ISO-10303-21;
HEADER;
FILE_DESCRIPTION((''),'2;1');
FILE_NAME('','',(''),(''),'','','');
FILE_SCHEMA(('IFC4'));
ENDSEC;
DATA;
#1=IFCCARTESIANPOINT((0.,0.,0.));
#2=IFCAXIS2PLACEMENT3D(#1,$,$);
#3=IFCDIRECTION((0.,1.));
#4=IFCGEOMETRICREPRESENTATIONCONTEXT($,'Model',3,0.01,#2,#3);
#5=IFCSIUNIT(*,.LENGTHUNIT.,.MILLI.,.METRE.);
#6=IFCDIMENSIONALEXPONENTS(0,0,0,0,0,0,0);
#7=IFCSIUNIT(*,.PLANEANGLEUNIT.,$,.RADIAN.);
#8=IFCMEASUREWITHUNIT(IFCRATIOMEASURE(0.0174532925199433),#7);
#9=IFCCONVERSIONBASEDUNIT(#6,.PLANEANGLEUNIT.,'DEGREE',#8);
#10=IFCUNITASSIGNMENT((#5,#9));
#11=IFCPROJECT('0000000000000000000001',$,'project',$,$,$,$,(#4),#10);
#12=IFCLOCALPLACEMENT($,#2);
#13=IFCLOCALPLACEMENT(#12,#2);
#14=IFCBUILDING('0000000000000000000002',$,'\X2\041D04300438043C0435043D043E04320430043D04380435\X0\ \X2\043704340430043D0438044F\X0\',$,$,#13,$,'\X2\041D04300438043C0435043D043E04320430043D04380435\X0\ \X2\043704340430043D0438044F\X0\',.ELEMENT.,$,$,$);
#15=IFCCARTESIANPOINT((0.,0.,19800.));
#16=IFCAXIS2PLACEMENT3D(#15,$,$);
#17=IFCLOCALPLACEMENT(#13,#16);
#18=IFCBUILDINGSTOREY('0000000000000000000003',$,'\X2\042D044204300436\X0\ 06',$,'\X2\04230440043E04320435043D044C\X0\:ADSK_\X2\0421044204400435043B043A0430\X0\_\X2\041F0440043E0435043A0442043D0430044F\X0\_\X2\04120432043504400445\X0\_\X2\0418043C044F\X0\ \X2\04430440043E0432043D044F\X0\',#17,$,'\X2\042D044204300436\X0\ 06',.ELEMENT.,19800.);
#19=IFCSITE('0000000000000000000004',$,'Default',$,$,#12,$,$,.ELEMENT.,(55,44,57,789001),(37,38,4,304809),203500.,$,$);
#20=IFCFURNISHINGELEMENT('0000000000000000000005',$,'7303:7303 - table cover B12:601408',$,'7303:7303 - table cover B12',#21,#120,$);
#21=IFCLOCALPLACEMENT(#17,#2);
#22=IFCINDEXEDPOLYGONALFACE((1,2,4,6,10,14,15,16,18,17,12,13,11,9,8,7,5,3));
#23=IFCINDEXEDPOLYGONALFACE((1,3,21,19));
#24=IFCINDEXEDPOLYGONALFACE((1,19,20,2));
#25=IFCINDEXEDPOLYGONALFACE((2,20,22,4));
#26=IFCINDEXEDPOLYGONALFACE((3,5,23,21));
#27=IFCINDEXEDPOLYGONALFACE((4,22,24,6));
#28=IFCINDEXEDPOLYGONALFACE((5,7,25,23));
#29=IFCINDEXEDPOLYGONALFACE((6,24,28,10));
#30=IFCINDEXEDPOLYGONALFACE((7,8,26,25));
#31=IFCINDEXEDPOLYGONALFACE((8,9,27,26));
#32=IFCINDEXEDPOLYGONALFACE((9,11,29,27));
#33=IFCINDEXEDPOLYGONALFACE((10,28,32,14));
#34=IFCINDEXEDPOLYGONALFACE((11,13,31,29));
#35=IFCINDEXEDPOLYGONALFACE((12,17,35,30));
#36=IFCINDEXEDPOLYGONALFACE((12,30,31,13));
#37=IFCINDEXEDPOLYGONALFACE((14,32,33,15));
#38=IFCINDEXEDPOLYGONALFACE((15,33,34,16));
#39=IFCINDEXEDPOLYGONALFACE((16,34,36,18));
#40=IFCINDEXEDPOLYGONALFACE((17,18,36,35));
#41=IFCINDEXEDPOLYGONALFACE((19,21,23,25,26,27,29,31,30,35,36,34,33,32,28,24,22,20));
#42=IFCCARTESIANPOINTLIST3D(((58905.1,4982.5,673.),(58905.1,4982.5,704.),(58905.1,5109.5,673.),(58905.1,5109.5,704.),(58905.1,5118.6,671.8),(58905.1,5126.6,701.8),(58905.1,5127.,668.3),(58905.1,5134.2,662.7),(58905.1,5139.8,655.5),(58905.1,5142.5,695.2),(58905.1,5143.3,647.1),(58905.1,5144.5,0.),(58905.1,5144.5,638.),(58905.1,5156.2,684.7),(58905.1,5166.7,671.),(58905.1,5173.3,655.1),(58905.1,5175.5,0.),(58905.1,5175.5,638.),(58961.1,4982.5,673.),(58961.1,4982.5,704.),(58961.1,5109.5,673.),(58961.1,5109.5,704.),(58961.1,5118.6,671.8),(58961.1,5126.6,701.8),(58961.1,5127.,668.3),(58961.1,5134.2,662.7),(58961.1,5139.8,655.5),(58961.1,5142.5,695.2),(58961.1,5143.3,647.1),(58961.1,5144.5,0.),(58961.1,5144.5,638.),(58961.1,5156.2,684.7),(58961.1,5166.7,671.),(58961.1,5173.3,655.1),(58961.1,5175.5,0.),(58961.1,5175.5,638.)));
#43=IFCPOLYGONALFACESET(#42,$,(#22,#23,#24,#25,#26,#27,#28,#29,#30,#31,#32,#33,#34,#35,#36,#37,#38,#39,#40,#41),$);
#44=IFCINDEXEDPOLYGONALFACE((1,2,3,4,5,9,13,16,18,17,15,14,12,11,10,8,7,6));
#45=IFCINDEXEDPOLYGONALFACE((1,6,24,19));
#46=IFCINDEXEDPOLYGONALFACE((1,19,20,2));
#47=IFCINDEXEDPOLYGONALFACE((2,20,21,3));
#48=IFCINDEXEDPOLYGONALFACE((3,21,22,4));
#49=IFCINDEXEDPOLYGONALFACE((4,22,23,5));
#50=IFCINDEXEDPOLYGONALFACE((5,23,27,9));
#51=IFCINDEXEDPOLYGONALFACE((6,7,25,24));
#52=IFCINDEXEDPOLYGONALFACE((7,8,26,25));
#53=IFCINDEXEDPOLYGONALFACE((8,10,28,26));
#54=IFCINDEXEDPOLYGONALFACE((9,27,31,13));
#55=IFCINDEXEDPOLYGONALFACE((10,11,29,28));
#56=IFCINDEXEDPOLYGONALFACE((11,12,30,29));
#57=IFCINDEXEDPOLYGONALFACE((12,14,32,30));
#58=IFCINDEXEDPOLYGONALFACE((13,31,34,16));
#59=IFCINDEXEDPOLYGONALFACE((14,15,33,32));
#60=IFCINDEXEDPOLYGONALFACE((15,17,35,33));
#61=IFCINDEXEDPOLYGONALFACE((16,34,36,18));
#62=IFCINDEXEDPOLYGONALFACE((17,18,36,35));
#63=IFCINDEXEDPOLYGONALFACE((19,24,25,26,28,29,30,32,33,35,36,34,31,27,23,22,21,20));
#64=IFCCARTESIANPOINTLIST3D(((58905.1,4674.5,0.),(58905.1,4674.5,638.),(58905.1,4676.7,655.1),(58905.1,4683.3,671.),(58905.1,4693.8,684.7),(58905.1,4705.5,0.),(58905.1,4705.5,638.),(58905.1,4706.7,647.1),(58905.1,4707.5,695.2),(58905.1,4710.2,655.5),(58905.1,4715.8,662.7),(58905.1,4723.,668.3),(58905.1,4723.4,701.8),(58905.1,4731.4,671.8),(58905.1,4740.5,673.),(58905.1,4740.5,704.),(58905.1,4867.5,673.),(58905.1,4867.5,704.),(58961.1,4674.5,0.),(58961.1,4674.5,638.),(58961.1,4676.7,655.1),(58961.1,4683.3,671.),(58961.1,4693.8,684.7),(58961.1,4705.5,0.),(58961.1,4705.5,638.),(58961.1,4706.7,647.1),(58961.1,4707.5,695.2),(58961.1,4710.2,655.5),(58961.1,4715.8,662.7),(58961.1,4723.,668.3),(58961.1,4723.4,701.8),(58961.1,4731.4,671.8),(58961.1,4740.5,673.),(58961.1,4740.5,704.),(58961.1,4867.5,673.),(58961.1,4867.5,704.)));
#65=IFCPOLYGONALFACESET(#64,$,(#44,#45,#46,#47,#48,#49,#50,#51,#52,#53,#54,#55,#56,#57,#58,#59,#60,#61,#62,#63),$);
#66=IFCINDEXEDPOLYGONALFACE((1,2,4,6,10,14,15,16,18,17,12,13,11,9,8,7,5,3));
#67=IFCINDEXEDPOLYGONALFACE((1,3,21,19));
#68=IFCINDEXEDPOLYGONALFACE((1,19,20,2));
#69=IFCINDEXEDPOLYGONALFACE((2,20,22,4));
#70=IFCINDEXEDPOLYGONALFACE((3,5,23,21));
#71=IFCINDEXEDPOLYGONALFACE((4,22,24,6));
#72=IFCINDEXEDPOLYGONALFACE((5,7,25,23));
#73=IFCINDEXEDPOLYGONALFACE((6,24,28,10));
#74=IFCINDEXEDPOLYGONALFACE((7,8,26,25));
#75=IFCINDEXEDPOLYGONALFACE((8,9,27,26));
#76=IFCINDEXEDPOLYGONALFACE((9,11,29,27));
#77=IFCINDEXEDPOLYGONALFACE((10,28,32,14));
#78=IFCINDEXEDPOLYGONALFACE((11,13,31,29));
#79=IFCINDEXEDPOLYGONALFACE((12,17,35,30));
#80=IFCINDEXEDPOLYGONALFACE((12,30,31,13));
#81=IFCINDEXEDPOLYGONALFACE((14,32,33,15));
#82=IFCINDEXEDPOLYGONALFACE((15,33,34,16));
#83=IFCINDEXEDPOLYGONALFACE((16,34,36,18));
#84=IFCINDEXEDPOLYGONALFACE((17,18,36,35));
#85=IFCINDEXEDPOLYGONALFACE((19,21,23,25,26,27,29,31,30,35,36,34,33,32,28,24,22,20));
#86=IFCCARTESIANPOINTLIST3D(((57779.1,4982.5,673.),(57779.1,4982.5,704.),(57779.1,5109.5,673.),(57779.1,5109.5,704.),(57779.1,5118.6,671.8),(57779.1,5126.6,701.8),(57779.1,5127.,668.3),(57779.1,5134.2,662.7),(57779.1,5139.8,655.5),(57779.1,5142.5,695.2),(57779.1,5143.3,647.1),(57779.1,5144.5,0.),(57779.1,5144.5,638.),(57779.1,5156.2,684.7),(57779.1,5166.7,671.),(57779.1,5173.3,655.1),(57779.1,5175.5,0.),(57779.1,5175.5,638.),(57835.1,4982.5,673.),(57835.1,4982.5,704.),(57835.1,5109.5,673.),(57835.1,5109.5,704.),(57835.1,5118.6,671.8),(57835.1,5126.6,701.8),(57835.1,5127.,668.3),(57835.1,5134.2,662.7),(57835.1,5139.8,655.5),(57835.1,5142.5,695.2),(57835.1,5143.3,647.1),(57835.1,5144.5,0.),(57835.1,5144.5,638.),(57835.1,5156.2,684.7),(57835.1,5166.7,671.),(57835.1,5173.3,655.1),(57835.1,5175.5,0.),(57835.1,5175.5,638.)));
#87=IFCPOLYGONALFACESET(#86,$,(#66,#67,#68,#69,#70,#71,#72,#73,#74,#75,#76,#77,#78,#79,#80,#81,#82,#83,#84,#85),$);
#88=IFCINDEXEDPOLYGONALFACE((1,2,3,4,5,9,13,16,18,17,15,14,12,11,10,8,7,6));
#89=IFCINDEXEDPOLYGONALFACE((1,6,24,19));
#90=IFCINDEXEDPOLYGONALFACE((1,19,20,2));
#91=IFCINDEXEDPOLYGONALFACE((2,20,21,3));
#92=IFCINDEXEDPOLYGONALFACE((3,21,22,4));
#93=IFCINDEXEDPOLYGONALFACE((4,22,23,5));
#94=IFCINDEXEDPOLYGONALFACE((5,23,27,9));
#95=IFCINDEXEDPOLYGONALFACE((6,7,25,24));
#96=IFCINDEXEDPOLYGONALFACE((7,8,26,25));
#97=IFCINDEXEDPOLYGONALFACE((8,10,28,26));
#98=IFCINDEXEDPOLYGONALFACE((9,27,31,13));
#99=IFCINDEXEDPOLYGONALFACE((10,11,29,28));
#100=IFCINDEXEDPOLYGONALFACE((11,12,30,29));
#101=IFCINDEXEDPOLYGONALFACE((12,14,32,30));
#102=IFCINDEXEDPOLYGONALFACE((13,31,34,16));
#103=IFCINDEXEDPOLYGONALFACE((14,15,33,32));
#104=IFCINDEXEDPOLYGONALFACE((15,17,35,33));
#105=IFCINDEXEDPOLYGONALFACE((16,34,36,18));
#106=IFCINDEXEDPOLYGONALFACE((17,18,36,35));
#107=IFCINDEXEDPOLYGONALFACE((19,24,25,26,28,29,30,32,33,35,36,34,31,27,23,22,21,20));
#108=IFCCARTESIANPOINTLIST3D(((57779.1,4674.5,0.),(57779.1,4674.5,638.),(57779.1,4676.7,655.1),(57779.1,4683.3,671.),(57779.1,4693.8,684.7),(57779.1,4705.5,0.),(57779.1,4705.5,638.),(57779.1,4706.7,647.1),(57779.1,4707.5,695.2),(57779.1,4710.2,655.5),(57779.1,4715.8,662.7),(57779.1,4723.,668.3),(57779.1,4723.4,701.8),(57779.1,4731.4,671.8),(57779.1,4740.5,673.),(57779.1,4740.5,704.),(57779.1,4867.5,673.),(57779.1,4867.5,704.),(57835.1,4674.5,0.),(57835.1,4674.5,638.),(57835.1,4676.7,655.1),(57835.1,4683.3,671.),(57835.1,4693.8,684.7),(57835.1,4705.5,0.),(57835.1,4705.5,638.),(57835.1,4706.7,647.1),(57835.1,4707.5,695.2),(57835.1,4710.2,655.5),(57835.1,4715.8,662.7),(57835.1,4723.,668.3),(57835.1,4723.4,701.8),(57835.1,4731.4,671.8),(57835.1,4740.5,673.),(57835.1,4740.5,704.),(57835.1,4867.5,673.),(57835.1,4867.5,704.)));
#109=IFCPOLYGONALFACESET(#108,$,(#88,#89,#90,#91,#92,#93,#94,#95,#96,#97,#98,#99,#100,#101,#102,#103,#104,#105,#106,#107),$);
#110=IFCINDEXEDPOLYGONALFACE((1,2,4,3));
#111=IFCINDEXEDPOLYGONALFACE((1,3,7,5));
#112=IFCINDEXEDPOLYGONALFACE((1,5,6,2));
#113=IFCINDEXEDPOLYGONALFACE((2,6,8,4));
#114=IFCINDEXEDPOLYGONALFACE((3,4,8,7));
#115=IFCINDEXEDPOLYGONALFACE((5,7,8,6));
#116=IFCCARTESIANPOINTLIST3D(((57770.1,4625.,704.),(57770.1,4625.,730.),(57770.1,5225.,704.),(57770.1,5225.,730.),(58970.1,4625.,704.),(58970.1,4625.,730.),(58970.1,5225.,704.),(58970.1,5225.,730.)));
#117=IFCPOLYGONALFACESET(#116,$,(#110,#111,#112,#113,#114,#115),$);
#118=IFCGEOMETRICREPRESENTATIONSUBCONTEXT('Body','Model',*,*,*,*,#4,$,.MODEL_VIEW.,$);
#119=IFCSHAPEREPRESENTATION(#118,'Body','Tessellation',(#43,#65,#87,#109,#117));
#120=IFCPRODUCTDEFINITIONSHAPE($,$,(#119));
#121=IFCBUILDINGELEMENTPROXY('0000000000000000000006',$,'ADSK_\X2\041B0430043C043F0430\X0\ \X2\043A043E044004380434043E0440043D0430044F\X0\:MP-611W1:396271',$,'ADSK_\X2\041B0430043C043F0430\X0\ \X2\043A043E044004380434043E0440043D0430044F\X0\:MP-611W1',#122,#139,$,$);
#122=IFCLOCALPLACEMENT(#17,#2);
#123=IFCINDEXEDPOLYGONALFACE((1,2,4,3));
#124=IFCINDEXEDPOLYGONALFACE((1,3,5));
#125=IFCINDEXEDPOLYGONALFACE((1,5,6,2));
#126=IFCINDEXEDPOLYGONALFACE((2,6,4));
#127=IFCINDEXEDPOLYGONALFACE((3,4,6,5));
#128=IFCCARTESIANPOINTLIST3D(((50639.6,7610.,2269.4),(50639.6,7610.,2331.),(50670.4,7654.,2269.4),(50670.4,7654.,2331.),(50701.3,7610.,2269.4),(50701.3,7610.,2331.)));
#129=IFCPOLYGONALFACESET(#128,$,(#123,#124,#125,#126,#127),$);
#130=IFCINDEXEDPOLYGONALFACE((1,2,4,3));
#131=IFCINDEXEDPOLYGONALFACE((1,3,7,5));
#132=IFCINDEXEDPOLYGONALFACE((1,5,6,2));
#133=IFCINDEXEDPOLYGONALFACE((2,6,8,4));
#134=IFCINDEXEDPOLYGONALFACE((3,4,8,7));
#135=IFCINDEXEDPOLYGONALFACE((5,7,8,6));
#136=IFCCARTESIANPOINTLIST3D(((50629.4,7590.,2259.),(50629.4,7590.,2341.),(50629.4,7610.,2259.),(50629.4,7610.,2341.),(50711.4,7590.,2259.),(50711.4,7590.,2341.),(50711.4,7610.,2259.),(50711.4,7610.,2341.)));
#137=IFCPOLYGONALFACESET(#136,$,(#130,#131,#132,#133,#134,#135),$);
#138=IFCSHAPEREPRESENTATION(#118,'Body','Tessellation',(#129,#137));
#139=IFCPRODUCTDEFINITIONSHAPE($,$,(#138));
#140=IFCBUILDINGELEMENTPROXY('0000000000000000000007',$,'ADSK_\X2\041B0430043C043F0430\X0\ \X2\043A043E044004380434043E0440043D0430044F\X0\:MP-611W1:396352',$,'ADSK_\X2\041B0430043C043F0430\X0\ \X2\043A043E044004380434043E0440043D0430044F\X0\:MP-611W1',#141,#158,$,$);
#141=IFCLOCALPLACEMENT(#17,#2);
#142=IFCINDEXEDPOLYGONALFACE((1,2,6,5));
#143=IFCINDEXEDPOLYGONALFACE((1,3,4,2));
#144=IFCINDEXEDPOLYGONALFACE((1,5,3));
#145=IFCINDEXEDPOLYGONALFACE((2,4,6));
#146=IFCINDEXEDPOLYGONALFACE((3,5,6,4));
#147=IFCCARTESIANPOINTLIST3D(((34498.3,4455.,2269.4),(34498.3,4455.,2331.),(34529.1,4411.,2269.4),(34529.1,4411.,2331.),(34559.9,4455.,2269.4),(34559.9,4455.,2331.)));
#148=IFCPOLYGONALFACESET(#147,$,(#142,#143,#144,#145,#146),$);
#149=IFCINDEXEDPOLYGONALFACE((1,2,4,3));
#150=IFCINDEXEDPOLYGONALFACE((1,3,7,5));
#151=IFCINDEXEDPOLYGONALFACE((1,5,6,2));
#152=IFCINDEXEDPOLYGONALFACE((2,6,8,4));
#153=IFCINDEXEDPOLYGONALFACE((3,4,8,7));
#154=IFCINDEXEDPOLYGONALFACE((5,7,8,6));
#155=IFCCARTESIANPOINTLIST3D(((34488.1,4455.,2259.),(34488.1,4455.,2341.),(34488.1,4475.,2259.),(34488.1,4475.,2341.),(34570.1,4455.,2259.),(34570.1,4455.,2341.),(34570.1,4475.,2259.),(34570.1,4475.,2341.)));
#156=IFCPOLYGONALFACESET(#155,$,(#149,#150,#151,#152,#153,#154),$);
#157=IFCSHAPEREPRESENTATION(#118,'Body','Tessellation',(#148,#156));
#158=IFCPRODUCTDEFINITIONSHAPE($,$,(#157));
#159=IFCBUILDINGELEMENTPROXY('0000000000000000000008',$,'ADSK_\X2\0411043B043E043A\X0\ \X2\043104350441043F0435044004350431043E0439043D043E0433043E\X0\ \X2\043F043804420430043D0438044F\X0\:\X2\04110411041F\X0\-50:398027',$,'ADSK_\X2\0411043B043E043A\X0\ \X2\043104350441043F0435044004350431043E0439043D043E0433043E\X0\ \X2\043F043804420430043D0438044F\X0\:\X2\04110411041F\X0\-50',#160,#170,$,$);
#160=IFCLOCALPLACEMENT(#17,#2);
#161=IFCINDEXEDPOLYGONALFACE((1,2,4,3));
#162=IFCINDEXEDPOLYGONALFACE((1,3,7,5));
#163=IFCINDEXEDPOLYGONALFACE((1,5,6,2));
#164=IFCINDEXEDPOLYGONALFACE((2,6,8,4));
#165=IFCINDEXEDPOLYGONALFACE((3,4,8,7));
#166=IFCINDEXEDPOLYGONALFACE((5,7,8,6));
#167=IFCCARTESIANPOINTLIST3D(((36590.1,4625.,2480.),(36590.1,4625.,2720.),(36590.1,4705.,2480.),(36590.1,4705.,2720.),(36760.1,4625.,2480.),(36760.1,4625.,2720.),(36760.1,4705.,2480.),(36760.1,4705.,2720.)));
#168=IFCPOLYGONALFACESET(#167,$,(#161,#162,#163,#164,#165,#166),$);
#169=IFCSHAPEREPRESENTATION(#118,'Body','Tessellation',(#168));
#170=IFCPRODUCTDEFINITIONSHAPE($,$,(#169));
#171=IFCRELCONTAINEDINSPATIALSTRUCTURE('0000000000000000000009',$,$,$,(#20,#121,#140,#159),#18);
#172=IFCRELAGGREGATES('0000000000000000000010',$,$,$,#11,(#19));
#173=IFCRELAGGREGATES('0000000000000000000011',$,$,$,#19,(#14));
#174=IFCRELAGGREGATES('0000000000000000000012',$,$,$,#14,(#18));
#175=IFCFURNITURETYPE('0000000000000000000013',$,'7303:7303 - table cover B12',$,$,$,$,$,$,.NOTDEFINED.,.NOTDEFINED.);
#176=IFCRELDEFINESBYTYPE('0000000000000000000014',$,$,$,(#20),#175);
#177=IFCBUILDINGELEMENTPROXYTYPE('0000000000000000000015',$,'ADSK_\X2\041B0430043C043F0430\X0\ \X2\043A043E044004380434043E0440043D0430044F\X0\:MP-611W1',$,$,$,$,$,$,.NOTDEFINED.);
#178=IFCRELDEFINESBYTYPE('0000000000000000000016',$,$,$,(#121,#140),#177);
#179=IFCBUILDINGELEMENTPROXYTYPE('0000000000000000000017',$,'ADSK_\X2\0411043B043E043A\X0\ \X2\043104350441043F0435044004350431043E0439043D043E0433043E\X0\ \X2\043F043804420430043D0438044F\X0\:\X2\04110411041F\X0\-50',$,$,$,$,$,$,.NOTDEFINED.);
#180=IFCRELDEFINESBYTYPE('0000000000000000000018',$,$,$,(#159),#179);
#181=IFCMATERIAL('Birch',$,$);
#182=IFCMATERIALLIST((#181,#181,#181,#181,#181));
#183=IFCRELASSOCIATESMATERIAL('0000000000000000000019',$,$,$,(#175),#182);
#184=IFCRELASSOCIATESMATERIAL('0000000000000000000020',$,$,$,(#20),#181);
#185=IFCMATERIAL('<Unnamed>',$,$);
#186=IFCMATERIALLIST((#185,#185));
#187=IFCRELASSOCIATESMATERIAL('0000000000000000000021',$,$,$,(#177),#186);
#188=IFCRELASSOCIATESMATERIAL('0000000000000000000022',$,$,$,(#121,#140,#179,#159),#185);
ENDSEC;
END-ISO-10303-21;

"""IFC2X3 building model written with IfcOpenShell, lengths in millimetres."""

from ifc_helpers import new_model, entity, si_unit, converted_unit, direction, frame, frame_2d, origin, origin_2d_with_axis, place, context, subcontext, project, spatial, polyline, circle_curve, parameter, trimmed, segment, composite_curve, rectangle, outline, extrude, source, transform, mapped, material, material_list, type_object, type_shapes, element, save


model = new_model("IFC2X3")

# Units and contexts
model_context = context("Model", 3, precision=0.01, world=origin(), true_north=direction((0.0, 1.0)))
body_context = subcontext(model_context, "Body", "Model", "MODEL_VIEW")
ifc_project = project(units=[si_unit("LENGTHUNIT", "METRE", prefix="MILLI"), converted_unit("PLANEANGLEUNIT", "DEGREE", entity("IfcRatioMeasure", 0.0174532925199433), si_unit("PLANEANGLEUNIT", "RADIAN"), dimensions=[0, 0, 0, 0, 0, 0, 0])], contexts=[model_context])

# Site, building, storey
site_placement = place(None, origin())
site = spatial("IfcSite", under=ifc_project, at=site_placement, Name="Default", CompositionType="ELEMENT", RefLatitude=(55, 44, 57, 789001), RefLongitude=(37, 38, 4, 304809), RefElevation=203500.0)
building_placement = place(site_placement, origin())
building = spatial("IfcBuilding", under=site, at=building_placement, Name="Наименование здания", LongName="Наименование здания", CompositionType="ELEMENT")
storey_placement = place(building_placement, frame((0.0, 0.0, 19800.0)))
storey = spatial("IfcBuildingStorey", under=building, at=storey_placement, Name="Этаж 06", ObjectType="Уровень:ADSK_Стрелка_Проектная_Вверх_Имя уровня", LongName="Этаж 06", CompositionType="ELEMENT", Elevation=19800.0)

# Furnishing element
ifc_material_1 = material(Name="Birch")
ifc_material_list_1 = material_list([ifc_material_1, ifc_material_1, ifc_material_1, ifc_material_1, ifc_material_1])
furniture_type = type_object("IfcFurnitureType", Name="7303:7303 - table cover B12", material=ifc_material_list_1)
shared_shape_1 = source(origin(), body_context, "Body", "SweptSolid", [
    extrude(outline(composite_curve([segment(polyline([(-200.2, -120.5), (-169.2, -120.5)]), True, "CONTINUOUS"), segment(polyline([(-169.2, -120.5), (-169.2, 6.5)]), True, "CONTINUOUS"), segment(trimmed(circle_curve(frame_2d((-134.2, 6.5), x_axis=(0.0, -1.0)), 35.0), [parameter(180.0)], [parameter(270.0)], True, "PARAMETER"), False, "CONTINUOUS"), segment(polyline([(-134.2, 41.5), (503.8, 41.5)]), True, "CONTINUOUS"), segment(polyline([(503.8, 41.5), (503.8, 72.5)]), True, "CONTINUOUS"), segment(polyline([(503.8, 72.5), (-134.2, 72.5)]), True, "CONTINUOUS"), segment(trimmed(circle_curve(frame_2d((-134.2, 6.5), x_axis=(0.0, -1.0)), 66.0), [parameter(180.0)], [parameter(270.0)], True, "PARAMETER"), True, "CONTINUOUS"), segment(polyline([(-200.2, 6.5), (-200.2, -120.5)]), True, "CONTINUOUS")], self_intersect=False)), frame((535.0, 178.0, 503.8), z_axis=(1.0, 0.0, 0.0), x_axis=(0.0, 0.0, -1.0)), (0.0, 0.0, 1.0), 56.0),
    extrude(outline(composite_curve([segment(polyline([(-120.5, -200.2), (6.5, -200.2)]), True, "CONTINUOUS"), segment(trimmed(circle_curve(frame_2d((6.5, -134.2), x_axis=(-1.0, 0.0)), 66.0), [parameter(90.0)], [parameter(180.0)], True, "PARAMETER"), True, "CONTINUOUS"), segment(polyline([(72.5, -134.2), (72.5, 503.8)]), True, "CONTINUOUS"), segment(polyline([(72.5, 503.8), (41.5, 503.8)]), True, "CONTINUOUS"), segment(polyline([(41.5, 503.8), (41.5, -134.2)]), True, "CONTINUOUS"), segment(trimmed(circle_curve(frame_2d((6.5, -134.2), x_axis=(-1.0, 0.0)), 35.0), [parameter(90.0)], [parameter(180.0)], True, "PARAMETER"), False, "CONTINUOUS"), segment(polyline([(6.5, -169.2), (-120.5, -169.2)]), True, "CONTINUOUS"), segment(polyline([(-120.5, -169.2), (-120.5, -200.2)]), True, "CONTINUOUS")], self_intersect=False)), frame((535.0, -178.0, 503.8), z_axis=(1.0, 0.0, 0.0), x_axis=(0.0, -1.0, 0.0)), (0.0, 0.0, 1.0), 56.0),
    extrude(outline(composite_curve([segment(polyline([(-200.2, -120.5), (-169.2, -120.5)]), True, "CONTINUOUS"), segment(polyline([(-169.2, -120.5), (-169.2, 6.5)]), True, "CONTINUOUS"), segment(trimmed(circle_curve(frame_2d((-134.2, 6.5), x_axis=(0.0, -1.0)), 35.0), [parameter(180.0)], [parameter(270.0)], True, "PARAMETER"), False, "CONTINUOUS"), segment(polyline([(-134.2, 41.5), (503.8, 41.5)]), True, "CONTINUOUS"), segment(polyline([(503.8, 41.5), (503.8, 72.5)]), True, "CONTINUOUS"), segment(polyline([(503.8, 72.5), (-134.2, 72.5)]), True, "CONTINUOUS"), segment(trimmed(circle_curve(frame_2d((-134.2, 6.5), x_axis=(0.0, -1.0)), 66.0), [parameter(180.0)], [parameter(270.0)], True, "PARAMETER"), True, "CONTINUOUS"), segment(polyline([(-200.2, 6.5), (-200.2, -120.5)]), True, "CONTINUOUS")], self_intersect=False)), frame((-591.0, 178.0, 503.8), z_axis=(1.0, 0.0, 0.0), x_axis=(0.0, 0.0, -1.0)), (0.0, 0.0, 1.0), 56.0),
    extrude(outline(composite_curve([segment(polyline([(-120.5, -200.2), (6.5, -200.2)]), True, "CONTINUOUS"), segment(trimmed(circle_curve(frame_2d((6.5, -134.2), x_axis=(-1.0, 0.0)), 66.0), [parameter(90.0)], [parameter(180.0)], True, "PARAMETER"), True, "CONTINUOUS"), segment(polyline([(72.5, -134.2), (72.5, 503.8)]), True, "CONTINUOUS"), segment(polyline([(72.5, 503.8), (41.5, 503.8)]), True, "CONTINUOUS"), segment(polyline([(41.5, 503.8), (41.5, -134.2)]), True, "CONTINUOUS"), segment(trimmed(circle_curve(frame_2d((6.5, -134.2), x_axis=(-1.0, 0.0)), 35.0), [parameter(90.0)], [parameter(180.0)], True, "PARAMETER"), False, "CONTINUOUS"), segment(polyline([(6.5, -169.2), (-120.5, -169.2)]), True, "CONTINUOUS"), segment(polyline([(-120.5, -169.2), (-120.5, -200.2)]), True, "CONTINUOUS")], self_intersect=False)), frame((-591.0, -178.0, 503.8), z_axis=(1.0, 0.0, 0.0), x_axis=(0.0, -1.0, 0.0)), (0.0, 0.0, 1.0), 56.0),
    extrude(rectangle(XDim=1200.0, YDim=600.0, at=origin_2d_with_axis()), frame((0.0, 0.0, 704.0), z_axis=(0.0, 0.0, 1.0), x_axis=(-1.0, 0.0, 0.0)), (0.0, 0.0, 1.0), 26.0),
])
type_shapes(furniture_type, [shared_shape_1])
for number, where, name in (
    (1, (58370.1, 4925.0, 0.0), "7303:7303 - table cover B12:601408"),
):
    element("IfcFurnishingElement", number, at=place(storey_placement, frame(where)), inside=storey, type_object=furniture_type, material=ifc_material_1, Name=name, ObjectType="7303:7303 - table cover B12", context=body_context, shape_type="MappedRepresentation", body=[
        mapped(shared_shape_1, transform((0.0, 0.0, 0.0), scale=1.0)),
    ])

# Building element proxies
ifc_material_2 = material(Name="<Unnamed>")
ifc_material_list_2 = material_list([ifc_material_2, ifc_material_2])
building_element_proxy_type_1 = type_object("IfcBuildingElementProxyType", Name="ADSK_Лампа коридорная:MP-611W1", PredefinedType="NOTDEFINED", material=ifc_material_list_2)
shared_shape_2 = source(origin(), body_context, "Body", "SweptSolid", [
    extrude(outline(polyline([(-30.8, -14.7), (30.8, -14.7), (0.0, 29.3), (-30.8, -14.7)])), frame((0.0, -2.7, -30.6), z_axis=(0.0, 0.0, 1.0), x_axis=(-1.0, 0.0, 0.0)), (0.0, 0.0, 1.0), 61.6),
    extrude(rectangle(XDim=82.0, YDim=20.0, at=origin_2d_with_axis()), frame((0.0, 22.0, -41.0), z_axis=(0.0, 0.0, 1.0), x_axis=(-1.0, 0.0, 0.0)), (0.0, 0.0, 1.0), 82.0),
])
type_shapes(building_element_proxy_type_1, [shared_shape_2])
proxy_1_placement = place(storey_placement, frame((50670.4, 7622.0, 2300.0), z_axis=(0.0, 0.0, 1.0), x_axis=(-1.0, 0.0, 0.0)))
element("IfcBuildingElementProxy", 2, at=proxy_1_placement, inside=storey, type_object=building_element_proxy_type_1, material=ifc_material_2, Name="ADSK_Лампа коридорная:MP-611W1:396271", ObjectType="ADSK_Лампа коридорная:MP-611W1", context=body_context, shape_type="MappedRepresentation", body=[
    mapped(shared_shape_2, transform((0.0, 0.0, 0.0), scale=1.0)),
])
proxy_2_placement = place(storey_placement, frame((34529.1, 4443.0, 2300.0)))
element("IfcBuildingElementProxy", 3, at=proxy_2_placement, inside=storey, type_object=building_element_proxy_type_1, material=ifc_material_2, Name="ADSK_Лампа коридорная:MP-611W1:396352", ObjectType="ADSK_Лампа коридорная:MP-611W1", context=body_context, shape_type="MappedRepresentation", body=[
    mapped(shared_shape_2, transform((0.0, 0.0, 0.0), scale=1.0)),
])
building_element_proxy_type_2 = type_object("IfcBuildingElementProxyType", Name="ADSK_Блок бесперебойного питания:ББП-50", PredefinedType="NOTDEFINED", material=ifc_material_2)
shared_shape_3 = source(origin(), body_context, "Body", "SweptSolid", [
    extrude(rectangle(XDim=170.0, YDim=80.0, at=origin_2d_with_axis()), frame((0.0, -8.0, -120.0), z_axis=(0.0, 0.0, 1.0), x_axis=(-1.0, 0.0, 0.0)), (0.0, 0.0, 1.0), 240.0),
])
type_shapes(building_element_proxy_type_2, [shared_shape_3])
for number, where, z_axis, x_axis, name in (
    (4, (36675.1, 4657.0, 2600.0), (0.0, 0.0, 1.0), (-1.0, 0.0, 0.0), "ADSK_Блок бесперебойного питания:ББП-50:398027"),
):
    element("IfcBuildingElementProxy", number, at=place(storey_placement, frame(where, z_axis=z_axis, x_axis=x_axis)), inside=storey, type_object=building_element_proxy_type_2, material=ifc_material_2, Name=name, ObjectType="ADSK_Блок бесперебойного питания:ББП-50", context=body_context, shape_type="MappedRepresentation", body=[
        mapped(shared_shape_3, transform((0.0, 0.0, 0.0), scale=1.0)),
    ])

save(model, "model.ifc")
